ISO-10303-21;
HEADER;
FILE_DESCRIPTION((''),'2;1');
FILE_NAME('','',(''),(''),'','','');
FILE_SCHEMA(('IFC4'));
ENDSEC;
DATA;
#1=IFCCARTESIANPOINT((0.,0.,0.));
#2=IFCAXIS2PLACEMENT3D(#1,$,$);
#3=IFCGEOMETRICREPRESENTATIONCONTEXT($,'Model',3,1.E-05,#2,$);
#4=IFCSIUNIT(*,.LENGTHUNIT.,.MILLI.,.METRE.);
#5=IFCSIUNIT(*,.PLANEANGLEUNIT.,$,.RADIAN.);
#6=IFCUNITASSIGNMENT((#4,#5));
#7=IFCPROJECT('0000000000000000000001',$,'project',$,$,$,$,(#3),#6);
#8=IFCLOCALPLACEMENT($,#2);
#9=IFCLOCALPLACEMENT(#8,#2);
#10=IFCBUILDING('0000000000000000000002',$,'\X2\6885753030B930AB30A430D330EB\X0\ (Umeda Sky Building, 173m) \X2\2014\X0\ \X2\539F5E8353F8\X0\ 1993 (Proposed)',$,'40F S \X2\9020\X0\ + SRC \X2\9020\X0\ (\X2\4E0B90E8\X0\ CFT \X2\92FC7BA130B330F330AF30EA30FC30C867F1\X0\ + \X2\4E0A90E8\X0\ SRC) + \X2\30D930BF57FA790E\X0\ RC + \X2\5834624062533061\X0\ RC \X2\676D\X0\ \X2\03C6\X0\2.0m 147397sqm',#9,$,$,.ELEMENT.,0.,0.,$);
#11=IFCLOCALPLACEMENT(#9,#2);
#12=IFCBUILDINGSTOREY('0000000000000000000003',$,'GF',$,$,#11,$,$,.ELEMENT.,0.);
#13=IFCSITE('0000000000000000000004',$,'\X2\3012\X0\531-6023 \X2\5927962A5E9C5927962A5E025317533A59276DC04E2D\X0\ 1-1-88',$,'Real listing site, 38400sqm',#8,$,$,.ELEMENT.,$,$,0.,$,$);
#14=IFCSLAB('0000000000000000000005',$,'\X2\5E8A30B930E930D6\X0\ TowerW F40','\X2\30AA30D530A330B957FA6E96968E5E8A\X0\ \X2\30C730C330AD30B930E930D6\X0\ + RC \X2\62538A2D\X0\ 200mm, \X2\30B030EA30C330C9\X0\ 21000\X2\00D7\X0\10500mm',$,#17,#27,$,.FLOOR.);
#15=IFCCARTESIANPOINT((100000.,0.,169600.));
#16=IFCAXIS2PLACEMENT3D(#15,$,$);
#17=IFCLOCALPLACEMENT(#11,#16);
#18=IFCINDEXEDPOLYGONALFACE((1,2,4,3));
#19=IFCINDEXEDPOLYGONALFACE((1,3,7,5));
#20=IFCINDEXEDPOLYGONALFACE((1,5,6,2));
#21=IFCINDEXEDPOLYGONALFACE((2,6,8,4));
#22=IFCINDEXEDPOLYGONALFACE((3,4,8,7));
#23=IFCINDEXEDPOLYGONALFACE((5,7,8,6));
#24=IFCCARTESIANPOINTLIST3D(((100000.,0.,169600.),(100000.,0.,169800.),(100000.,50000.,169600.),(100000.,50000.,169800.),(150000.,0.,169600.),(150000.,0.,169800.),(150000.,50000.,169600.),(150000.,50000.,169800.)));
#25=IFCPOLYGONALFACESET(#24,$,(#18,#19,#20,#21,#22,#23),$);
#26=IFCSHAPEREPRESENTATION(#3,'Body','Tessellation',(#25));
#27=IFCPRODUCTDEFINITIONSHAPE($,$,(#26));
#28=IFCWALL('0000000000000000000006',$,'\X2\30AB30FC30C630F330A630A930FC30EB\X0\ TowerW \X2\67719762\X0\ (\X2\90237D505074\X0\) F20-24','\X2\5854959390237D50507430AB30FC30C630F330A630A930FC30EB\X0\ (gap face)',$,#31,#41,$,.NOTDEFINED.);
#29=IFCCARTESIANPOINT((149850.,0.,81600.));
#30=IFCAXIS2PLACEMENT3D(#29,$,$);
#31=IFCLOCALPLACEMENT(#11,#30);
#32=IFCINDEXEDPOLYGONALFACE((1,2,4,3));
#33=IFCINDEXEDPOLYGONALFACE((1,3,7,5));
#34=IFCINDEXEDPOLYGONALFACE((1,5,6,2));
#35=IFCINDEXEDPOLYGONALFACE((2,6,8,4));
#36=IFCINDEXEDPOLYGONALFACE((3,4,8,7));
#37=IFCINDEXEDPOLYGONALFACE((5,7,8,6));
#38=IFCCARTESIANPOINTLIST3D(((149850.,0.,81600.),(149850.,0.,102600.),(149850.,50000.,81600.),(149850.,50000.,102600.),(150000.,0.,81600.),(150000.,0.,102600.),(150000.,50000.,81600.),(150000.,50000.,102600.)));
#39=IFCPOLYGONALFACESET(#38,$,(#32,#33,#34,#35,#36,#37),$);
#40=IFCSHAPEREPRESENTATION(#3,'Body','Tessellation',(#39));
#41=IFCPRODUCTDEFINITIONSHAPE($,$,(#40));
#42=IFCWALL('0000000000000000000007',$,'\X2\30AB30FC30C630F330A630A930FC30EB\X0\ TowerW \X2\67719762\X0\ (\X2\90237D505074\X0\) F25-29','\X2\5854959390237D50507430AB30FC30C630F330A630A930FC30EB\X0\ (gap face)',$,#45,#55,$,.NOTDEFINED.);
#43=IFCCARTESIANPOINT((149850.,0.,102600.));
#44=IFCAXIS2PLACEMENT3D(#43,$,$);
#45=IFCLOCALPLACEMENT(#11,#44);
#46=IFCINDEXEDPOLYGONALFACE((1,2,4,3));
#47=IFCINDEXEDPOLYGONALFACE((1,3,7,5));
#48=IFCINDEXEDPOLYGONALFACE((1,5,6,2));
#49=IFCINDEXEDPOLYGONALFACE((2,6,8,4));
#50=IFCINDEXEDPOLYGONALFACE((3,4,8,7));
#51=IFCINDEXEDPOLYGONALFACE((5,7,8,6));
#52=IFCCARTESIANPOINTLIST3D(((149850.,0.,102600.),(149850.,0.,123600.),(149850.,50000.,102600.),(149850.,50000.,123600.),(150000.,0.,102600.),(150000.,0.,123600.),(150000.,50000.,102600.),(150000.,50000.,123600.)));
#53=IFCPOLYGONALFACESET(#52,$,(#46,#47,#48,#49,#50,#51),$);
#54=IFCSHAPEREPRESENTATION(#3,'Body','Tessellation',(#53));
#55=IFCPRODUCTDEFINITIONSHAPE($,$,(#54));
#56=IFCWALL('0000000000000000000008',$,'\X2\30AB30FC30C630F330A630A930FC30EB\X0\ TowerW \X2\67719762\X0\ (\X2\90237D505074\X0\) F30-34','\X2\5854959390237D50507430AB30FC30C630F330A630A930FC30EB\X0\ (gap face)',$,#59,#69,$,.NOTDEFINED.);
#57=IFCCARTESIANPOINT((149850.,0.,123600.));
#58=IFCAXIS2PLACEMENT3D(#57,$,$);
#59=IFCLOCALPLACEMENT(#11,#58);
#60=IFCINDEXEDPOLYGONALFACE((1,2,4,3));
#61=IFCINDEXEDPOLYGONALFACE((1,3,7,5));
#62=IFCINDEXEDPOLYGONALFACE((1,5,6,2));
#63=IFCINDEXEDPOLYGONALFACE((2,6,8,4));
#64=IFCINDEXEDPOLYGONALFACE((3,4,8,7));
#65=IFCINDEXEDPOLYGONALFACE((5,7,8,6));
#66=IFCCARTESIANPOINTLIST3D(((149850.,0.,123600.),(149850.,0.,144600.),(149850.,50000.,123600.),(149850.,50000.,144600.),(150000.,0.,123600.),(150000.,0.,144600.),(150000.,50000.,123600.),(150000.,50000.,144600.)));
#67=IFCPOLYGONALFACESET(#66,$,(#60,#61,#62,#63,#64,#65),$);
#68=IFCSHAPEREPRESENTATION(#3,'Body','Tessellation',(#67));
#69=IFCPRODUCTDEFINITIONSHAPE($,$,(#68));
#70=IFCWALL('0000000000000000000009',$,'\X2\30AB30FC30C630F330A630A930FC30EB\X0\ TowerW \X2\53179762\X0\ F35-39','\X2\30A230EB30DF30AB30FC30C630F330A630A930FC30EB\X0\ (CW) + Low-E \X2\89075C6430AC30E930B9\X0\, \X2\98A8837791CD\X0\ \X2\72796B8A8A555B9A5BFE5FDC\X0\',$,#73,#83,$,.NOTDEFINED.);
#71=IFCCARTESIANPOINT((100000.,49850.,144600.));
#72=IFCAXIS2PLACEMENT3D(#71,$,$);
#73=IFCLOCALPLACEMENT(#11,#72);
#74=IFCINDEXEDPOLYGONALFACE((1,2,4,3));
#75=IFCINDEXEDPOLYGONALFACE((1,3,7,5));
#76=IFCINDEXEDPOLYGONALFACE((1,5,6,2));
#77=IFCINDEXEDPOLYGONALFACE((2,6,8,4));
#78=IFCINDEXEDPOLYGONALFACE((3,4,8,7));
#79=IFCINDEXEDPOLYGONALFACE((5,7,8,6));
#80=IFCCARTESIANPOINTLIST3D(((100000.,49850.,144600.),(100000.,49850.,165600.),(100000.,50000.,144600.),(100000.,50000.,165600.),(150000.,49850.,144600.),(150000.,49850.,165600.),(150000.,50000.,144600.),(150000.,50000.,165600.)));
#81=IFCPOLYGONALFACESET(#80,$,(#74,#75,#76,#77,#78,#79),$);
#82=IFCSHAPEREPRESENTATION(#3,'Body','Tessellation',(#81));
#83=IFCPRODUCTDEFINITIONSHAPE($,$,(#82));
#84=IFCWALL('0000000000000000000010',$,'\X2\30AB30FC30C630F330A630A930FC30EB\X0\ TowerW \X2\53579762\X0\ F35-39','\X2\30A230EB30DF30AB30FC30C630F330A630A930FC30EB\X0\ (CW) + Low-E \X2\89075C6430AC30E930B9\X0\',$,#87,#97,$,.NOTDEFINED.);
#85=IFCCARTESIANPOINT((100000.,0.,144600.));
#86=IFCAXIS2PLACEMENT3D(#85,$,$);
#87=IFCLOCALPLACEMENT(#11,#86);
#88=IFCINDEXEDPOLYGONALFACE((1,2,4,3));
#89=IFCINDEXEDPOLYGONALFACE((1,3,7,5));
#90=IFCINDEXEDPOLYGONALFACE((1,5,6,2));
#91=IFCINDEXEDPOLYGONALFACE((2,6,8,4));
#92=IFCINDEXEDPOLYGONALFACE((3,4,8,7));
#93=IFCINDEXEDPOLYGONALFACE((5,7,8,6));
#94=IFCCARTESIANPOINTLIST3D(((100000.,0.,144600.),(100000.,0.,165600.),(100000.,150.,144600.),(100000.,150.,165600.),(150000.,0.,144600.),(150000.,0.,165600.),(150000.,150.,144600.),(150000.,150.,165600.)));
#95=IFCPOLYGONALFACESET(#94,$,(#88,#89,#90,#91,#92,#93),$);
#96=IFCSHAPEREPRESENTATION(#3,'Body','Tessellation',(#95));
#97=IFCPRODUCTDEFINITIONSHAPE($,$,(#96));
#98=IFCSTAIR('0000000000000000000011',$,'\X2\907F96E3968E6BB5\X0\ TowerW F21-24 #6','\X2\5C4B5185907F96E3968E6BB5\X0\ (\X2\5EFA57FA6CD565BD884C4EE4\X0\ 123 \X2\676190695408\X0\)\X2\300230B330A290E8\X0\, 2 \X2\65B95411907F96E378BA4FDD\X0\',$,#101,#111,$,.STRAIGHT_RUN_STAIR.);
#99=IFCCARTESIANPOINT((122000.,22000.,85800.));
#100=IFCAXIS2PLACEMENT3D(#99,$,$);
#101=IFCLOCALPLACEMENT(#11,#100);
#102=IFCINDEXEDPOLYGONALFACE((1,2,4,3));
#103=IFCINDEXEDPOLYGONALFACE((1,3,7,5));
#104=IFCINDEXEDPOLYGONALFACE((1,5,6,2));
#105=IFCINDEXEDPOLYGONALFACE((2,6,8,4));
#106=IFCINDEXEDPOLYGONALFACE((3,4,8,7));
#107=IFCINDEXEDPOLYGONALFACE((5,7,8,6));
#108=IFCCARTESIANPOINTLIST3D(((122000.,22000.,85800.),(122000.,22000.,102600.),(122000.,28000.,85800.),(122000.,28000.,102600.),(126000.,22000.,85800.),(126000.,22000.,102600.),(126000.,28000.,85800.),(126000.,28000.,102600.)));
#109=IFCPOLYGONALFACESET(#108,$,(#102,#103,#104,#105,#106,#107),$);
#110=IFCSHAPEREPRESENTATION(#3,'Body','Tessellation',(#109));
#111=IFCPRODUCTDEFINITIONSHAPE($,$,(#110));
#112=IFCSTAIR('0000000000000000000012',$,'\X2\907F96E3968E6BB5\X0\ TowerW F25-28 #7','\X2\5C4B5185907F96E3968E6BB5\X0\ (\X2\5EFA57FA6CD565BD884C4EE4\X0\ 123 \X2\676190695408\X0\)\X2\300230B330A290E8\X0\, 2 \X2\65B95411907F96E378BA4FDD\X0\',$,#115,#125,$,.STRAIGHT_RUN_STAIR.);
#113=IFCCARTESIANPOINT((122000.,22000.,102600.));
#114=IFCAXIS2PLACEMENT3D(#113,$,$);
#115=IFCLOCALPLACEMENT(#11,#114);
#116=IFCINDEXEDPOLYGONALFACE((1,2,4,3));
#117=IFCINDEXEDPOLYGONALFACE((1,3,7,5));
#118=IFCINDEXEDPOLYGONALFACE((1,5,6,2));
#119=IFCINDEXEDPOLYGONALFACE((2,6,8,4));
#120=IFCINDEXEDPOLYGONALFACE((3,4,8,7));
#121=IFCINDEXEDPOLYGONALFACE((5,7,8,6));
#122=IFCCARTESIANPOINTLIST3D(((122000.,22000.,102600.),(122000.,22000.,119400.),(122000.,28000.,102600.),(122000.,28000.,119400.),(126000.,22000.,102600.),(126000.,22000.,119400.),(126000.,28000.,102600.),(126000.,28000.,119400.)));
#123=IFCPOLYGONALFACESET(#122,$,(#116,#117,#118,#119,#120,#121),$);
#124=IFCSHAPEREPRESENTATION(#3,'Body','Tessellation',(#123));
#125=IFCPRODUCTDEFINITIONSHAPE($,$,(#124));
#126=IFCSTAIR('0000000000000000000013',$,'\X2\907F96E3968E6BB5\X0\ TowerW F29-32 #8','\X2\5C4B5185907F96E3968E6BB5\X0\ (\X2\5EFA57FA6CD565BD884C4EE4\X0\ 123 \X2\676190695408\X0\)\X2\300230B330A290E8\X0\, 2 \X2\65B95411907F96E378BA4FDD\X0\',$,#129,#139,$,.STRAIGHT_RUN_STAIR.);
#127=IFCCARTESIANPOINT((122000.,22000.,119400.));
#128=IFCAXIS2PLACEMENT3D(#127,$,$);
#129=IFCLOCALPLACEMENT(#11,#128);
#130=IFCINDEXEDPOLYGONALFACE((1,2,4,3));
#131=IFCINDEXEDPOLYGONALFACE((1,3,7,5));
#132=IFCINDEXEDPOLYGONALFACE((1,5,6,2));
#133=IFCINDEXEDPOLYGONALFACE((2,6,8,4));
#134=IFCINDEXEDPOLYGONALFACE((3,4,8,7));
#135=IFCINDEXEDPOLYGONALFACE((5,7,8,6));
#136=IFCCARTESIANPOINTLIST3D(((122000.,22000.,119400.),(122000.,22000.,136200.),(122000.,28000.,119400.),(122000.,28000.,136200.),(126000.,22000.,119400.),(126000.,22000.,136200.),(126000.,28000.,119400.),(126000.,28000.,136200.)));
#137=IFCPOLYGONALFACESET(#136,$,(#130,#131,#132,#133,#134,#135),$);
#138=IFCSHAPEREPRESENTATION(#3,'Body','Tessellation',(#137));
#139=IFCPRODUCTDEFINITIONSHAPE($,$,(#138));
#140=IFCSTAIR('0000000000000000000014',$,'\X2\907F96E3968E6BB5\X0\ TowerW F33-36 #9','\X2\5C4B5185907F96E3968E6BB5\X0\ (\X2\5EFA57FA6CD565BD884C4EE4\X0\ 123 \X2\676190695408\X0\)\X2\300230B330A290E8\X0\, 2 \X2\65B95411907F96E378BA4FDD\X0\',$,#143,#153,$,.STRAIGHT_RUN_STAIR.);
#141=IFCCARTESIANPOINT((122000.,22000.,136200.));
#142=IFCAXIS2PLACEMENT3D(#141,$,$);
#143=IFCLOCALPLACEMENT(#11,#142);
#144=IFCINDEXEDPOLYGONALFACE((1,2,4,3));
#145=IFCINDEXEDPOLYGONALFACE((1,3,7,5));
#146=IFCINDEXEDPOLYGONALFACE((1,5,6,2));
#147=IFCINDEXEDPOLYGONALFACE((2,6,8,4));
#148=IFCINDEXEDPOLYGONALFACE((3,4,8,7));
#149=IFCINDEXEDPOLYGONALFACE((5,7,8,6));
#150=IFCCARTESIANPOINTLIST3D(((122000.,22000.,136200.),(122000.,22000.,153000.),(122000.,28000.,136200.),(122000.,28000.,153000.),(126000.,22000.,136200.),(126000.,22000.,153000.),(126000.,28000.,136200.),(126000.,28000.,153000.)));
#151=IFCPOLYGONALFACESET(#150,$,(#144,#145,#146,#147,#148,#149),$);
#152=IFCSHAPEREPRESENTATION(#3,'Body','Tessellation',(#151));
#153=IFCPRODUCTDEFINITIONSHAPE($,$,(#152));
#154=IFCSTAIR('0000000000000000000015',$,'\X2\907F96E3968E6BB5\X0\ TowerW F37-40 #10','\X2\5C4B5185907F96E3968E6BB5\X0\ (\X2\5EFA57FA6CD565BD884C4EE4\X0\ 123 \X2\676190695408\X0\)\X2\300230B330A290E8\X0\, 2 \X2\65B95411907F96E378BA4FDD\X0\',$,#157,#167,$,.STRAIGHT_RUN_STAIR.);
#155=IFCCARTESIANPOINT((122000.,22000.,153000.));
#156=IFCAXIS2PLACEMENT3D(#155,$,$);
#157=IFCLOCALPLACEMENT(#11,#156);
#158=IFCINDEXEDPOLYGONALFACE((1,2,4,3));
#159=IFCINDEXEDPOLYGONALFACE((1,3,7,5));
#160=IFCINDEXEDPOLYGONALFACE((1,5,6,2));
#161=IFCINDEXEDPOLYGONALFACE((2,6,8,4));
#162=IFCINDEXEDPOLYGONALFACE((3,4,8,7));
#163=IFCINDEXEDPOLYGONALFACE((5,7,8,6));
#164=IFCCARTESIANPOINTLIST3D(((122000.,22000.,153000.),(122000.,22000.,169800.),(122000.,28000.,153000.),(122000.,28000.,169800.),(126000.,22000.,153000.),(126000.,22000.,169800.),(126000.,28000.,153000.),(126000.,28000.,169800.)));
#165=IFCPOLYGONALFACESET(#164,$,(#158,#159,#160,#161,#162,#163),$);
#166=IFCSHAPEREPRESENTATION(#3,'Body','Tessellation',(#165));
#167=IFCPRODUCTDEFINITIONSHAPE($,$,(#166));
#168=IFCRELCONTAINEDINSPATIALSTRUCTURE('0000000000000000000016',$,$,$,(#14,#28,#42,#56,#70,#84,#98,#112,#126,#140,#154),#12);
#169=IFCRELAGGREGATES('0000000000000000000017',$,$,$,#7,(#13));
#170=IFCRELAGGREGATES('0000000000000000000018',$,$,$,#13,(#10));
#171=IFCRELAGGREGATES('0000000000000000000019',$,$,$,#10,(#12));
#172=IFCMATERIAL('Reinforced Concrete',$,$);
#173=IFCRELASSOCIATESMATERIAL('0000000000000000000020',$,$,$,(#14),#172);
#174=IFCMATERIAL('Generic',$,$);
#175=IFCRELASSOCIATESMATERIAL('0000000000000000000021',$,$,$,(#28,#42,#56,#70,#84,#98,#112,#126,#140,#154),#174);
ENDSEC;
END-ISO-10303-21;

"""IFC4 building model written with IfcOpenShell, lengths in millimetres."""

from ifc_helpers import new_model, si_unit, frame, frame_2d, origin, place, context, project, spatial, rectangle, extrude, material, element, save


model = new_model("IFC4")

# Units and contexts
model_context = context("Model", 3, precision=1e-05, world=origin())
ifc_project = project(units=[si_unit("LENGTHUNIT", "METRE", prefix="MILLI"), si_unit("PLANEANGLEUNIT", "RADIAN")], contexts=[model_context])

# Site, building, storey
site_placement = place(None, origin())
site = spatial("IfcSite", under=ifc_project, at=site_placement, Name="〒531-6023 大阪府大阪市北区大淀中 1-1-88", ObjectType="Real listing site, 38400sqm", CompositionType="ELEMENT", RefElevation=0.0)
building_placement = place(site_placement, origin())
building = spatial("IfcBuilding", under=site, at=building_placement, Name="梅田スカイビル (Umeda Sky Building, 173m) — 原広司 1993 (Proposed)", ObjectType="40F S 造 + SRC 造 (下部 CFT 鋼管コンクリート柱 + 上部 SRC) + ベタ基礎 RC + 場所打ち RC 杭 φ2.0m 147397sqm", CompositionType="ELEMENT", ElevationOfRefHeight=0.0, ElevationOfTerrain=0.0)
storey_placement = place(building_placement, origin())
storey = spatial("IfcBuildingStorey", under=building, at=storey_placement, Name="GF", CompositionType="ELEMENT", Elevation=0.0)

# Shared definitions
ifc_material_1 = material(Name="Reinforced Concrete")

# Slab
slab_1_placement = place(storey_placement, frame((100000.0, 0.0, 169600.0)))
element("IfcSlab", 1, at=slab_1_placement, inside=storey, material=ifc_material_1, Name="床スラブ TowerW F40", Description="オフィス基準階床 デッキスラブ + RC 打設 200mm, グリッド 21000×10500mm", PredefinedType="FLOOR", context=model_context, shape_type="SweptSolid", body=[
    extrude(rectangle(XDim=50000.0, YDim=50000.0, at=frame_2d((25000.0, 25000.0))), frame((100000.0, 0.0, 169600.0)), (0.0, 0.0, 1.0), 200.0),
])

# Walls
ifc_material_2 = material(Name="Generic")
wall_1_placement = place(storey_placement, frame((149850.0, 0.0, 81600.0)))
element("IfcWall", 2, at=wall_1_placement, inside=storey, material=ifc_material_2, Name="カーテンウォール TowerW 東面 (連結側) F20-24", Description="塔間連結側カーテンウォール (gap face)", PredefinedType="NOTDEFINED", context=model_context, shape_type="SweptSolid", body=[
    extrude(rectangle(XDim=150.0, YDim=50000.0, at=frame_2d((75.0, 25000.0))), frame((149850.0, 0.0, 81600.0)), (0.0, 0.0, 1.0), 21000.0),
])
wall_2_placement = place(storey_placement, frame((149850.0, 0.0, 102600.0)))
element("IfcWall", 3, at=wall_2_placement, inside=storey, material=ifc_material_2, Name="カーテンウォール TowerW 東面 (連結側) F25-29", Description="塔間連結側カーテンウォール (gap face)", PredefinedType="NOTDEFINED", context=model_context, shape_type="SweptSolid", body=[
    extrude(rectangle(XDim=150.0, YDim=50000.0, at=frame_2d((75.0, 25000.0))), frame((149850.0, 0.0, 102600.0)), (0.0, 0.0, 1.0), 21000.0),
])
wall_3_placement = place(storey_placement, frame((149850.0, 0.0, 123600.0)))
element("IfcWall", 4, at=wall_3_placement, inside=storey, material=ifc_material_2, Name="カーテンウォール TowerW 東面 (連結側) F30-34", Description="塔間連結側カーテンウォール (gap face)", PredefinedType="NOTDEFINED", context=model_context, shape_type="SweptSolid", body=[
    extrude(rectangle(XDim=150.0, YDim=50000.0, at=frame_2d((75.0, 25000.0))), frame((149850.0, 0.0, 123600.0)), (0.0, 0.0, 1.0), 21000.0),
])
wall_4_placement = place(storey_placement, frame((100000.0, 49850.0, 144600.0)))
element("IfcWall", 5, at=wall_4_placement, inside=storey, material=ifc_material_2, Name="カーテンウォール TowerW 北面 F35-39", Description="アルミカーテンウォール (CW) + Low-E 複層ガラス, 風荷重 特殊評定対応", PredefinedType="NOTDEFINED", context=model_context, shape_type="SweptSolid", body=[
    extrude(rectangle(XDim=50000.0, YDim=150.0, at=frame_2d((25000.0, 75.0))), frame((100000.0, 49850.0, 144600.0)), (0.0, 0.0, 1.0), 21000.0),
])
wall_5_placement = place(storey_placement, frame((100000.0, 0.0, 144600.0)))
element("IfcWall", 6, at=wall_5_placement, inside=storey, material=ifc_material_2, Name="カーテンウォール TowerW 南面 F35-39", Description="アルミカーテンウォール (CW) + Low-E 複層ガラス", PredefinedType="NOTDEFINED", context=model_context, shape_type="SweptSolid", body=[
    extrude(rectangle(XDim=50000.0, YDim=150.0, at=frame_2d((25000.0, 75.0))), frame((100000.0, 0.0, 144600.0)), (0.0, 0.0, 1.0), 21000.0),
])

# Stairs
stair_1_placement = place(storey_placement, frame((122000.0, 22000.0, 85800.0)))
element("IfcStair", 7, at=stair_1_placement, inside=storey, material=ifc_material_2, Name="避難階段 TowerW F21-24 #6", Description="屋内避難階段 (建基法施行令 123 条適合)。コア部, 2 方向避難確保", PredefinedType="STRAIGHT_RUN_STAIR", context=model_context, shape_type="SweptSolid", body=[
    extrude(rectangle(XDim=4000.0, YDim=6000.0, at=frame_2d((2000.0, 3000.0))), frame((122000.0, 22000.0, 85800.0)), (0.0, 0.0, 1.0), 16800.0),
])
stair_2_placement = place(storey_placement, frame((122000.0, 22000.0, 102600.0)))
element("IfcStair", 8, at=stair_2_placement, inside=storey, material=ifc_material_2, Name="避難階段 TowerW F25-28 #7", Description="屋内避難階段 (建基法施行令 123 条適合)。コア部, 2 方向避難確保", PredefinedType="STRAIGHT_RUN_STAIR", context=model_context, shape_type="SweptSolid", body=[
    extrude(rectangle(XDim=4000.0, YDim=6000.0, at=frame_2d((2000.0, 3000.0))), frame((122000.0, 22000.0, 102600.0)), (0.0, 0.0, 1.0), 16800.0),
])
stair_3_placement = place(storey_placement, frame((122000.0, 22000.0, 119400.0)))
element("IfcStair", 9, at=stair_3_placement, inside=storey, material=ifc_material_2, Name="避難階段 TowerW F29-32 #8", Description="屋内避難階段 (建基法施行令 123 条適合)。コア部, 2 方向避難確保", PredefinedType="STRAIGHT_RUN_STAIR", context=model_context, shape_type="SweptSolid", body=[
    extrude(rectangle(XDim=4000.0, YDim=6000.0, at=frame_2d((2000.0, 3000.0))), frame((122000.0, 22000.0, 119400.0)), (0.0, 0.0, 1.0), 16800.0),
])
stair_4_placement = place(storey_placement, frame((122000.0, 22000.0, 136200.0)))
element("IfcStair", 10, at=stair_4_placement, inside=storey, material=ifc_material_2, Name="避難階段 TowerW F33-36 #9", Description="屋内避難階段 (建基法施行令 123 条適合)。コア部, 2 方向避難確保", PredefinedType="STRAIGHT_RUN_STAIR", context=model_context, shape_type="SweptSolid", body=[
    extrude(rectangle(XDim=4000.0, YDim=6000.0, at=frame_2d((2000.0, 3000.0))), frame((122000.0, 22000.0, 136200.0)), (0.0, 0.0, 1.0), 16800.0),
])
stair_5_placement = place(storey_placement, frame((122000.0, 22000.0, 153000.0)))
element("IfcStair", 11, at=stair_5_placement, inside=storey, material=ifc_material_2, Name="避難階段 TowerW F37-40 #10", Description="屋内避難階段 (建基法施行令 123 条適合)。コア部, 2 方向避難確保", PredefinedType="STRAIGHT_RUN_STAIR", context=model_context, shape_type="SweptSolid", body=[
    extrude(rectangle(XDim=4000.0, YDim=6000.0, at=frame_2d((2000.0, 3000.0))), frame((122000.0, 22000.0, 153000.0)), (0.0, 0.0, 1.0), 16800.0),
])

save(model, "model.ifc")
